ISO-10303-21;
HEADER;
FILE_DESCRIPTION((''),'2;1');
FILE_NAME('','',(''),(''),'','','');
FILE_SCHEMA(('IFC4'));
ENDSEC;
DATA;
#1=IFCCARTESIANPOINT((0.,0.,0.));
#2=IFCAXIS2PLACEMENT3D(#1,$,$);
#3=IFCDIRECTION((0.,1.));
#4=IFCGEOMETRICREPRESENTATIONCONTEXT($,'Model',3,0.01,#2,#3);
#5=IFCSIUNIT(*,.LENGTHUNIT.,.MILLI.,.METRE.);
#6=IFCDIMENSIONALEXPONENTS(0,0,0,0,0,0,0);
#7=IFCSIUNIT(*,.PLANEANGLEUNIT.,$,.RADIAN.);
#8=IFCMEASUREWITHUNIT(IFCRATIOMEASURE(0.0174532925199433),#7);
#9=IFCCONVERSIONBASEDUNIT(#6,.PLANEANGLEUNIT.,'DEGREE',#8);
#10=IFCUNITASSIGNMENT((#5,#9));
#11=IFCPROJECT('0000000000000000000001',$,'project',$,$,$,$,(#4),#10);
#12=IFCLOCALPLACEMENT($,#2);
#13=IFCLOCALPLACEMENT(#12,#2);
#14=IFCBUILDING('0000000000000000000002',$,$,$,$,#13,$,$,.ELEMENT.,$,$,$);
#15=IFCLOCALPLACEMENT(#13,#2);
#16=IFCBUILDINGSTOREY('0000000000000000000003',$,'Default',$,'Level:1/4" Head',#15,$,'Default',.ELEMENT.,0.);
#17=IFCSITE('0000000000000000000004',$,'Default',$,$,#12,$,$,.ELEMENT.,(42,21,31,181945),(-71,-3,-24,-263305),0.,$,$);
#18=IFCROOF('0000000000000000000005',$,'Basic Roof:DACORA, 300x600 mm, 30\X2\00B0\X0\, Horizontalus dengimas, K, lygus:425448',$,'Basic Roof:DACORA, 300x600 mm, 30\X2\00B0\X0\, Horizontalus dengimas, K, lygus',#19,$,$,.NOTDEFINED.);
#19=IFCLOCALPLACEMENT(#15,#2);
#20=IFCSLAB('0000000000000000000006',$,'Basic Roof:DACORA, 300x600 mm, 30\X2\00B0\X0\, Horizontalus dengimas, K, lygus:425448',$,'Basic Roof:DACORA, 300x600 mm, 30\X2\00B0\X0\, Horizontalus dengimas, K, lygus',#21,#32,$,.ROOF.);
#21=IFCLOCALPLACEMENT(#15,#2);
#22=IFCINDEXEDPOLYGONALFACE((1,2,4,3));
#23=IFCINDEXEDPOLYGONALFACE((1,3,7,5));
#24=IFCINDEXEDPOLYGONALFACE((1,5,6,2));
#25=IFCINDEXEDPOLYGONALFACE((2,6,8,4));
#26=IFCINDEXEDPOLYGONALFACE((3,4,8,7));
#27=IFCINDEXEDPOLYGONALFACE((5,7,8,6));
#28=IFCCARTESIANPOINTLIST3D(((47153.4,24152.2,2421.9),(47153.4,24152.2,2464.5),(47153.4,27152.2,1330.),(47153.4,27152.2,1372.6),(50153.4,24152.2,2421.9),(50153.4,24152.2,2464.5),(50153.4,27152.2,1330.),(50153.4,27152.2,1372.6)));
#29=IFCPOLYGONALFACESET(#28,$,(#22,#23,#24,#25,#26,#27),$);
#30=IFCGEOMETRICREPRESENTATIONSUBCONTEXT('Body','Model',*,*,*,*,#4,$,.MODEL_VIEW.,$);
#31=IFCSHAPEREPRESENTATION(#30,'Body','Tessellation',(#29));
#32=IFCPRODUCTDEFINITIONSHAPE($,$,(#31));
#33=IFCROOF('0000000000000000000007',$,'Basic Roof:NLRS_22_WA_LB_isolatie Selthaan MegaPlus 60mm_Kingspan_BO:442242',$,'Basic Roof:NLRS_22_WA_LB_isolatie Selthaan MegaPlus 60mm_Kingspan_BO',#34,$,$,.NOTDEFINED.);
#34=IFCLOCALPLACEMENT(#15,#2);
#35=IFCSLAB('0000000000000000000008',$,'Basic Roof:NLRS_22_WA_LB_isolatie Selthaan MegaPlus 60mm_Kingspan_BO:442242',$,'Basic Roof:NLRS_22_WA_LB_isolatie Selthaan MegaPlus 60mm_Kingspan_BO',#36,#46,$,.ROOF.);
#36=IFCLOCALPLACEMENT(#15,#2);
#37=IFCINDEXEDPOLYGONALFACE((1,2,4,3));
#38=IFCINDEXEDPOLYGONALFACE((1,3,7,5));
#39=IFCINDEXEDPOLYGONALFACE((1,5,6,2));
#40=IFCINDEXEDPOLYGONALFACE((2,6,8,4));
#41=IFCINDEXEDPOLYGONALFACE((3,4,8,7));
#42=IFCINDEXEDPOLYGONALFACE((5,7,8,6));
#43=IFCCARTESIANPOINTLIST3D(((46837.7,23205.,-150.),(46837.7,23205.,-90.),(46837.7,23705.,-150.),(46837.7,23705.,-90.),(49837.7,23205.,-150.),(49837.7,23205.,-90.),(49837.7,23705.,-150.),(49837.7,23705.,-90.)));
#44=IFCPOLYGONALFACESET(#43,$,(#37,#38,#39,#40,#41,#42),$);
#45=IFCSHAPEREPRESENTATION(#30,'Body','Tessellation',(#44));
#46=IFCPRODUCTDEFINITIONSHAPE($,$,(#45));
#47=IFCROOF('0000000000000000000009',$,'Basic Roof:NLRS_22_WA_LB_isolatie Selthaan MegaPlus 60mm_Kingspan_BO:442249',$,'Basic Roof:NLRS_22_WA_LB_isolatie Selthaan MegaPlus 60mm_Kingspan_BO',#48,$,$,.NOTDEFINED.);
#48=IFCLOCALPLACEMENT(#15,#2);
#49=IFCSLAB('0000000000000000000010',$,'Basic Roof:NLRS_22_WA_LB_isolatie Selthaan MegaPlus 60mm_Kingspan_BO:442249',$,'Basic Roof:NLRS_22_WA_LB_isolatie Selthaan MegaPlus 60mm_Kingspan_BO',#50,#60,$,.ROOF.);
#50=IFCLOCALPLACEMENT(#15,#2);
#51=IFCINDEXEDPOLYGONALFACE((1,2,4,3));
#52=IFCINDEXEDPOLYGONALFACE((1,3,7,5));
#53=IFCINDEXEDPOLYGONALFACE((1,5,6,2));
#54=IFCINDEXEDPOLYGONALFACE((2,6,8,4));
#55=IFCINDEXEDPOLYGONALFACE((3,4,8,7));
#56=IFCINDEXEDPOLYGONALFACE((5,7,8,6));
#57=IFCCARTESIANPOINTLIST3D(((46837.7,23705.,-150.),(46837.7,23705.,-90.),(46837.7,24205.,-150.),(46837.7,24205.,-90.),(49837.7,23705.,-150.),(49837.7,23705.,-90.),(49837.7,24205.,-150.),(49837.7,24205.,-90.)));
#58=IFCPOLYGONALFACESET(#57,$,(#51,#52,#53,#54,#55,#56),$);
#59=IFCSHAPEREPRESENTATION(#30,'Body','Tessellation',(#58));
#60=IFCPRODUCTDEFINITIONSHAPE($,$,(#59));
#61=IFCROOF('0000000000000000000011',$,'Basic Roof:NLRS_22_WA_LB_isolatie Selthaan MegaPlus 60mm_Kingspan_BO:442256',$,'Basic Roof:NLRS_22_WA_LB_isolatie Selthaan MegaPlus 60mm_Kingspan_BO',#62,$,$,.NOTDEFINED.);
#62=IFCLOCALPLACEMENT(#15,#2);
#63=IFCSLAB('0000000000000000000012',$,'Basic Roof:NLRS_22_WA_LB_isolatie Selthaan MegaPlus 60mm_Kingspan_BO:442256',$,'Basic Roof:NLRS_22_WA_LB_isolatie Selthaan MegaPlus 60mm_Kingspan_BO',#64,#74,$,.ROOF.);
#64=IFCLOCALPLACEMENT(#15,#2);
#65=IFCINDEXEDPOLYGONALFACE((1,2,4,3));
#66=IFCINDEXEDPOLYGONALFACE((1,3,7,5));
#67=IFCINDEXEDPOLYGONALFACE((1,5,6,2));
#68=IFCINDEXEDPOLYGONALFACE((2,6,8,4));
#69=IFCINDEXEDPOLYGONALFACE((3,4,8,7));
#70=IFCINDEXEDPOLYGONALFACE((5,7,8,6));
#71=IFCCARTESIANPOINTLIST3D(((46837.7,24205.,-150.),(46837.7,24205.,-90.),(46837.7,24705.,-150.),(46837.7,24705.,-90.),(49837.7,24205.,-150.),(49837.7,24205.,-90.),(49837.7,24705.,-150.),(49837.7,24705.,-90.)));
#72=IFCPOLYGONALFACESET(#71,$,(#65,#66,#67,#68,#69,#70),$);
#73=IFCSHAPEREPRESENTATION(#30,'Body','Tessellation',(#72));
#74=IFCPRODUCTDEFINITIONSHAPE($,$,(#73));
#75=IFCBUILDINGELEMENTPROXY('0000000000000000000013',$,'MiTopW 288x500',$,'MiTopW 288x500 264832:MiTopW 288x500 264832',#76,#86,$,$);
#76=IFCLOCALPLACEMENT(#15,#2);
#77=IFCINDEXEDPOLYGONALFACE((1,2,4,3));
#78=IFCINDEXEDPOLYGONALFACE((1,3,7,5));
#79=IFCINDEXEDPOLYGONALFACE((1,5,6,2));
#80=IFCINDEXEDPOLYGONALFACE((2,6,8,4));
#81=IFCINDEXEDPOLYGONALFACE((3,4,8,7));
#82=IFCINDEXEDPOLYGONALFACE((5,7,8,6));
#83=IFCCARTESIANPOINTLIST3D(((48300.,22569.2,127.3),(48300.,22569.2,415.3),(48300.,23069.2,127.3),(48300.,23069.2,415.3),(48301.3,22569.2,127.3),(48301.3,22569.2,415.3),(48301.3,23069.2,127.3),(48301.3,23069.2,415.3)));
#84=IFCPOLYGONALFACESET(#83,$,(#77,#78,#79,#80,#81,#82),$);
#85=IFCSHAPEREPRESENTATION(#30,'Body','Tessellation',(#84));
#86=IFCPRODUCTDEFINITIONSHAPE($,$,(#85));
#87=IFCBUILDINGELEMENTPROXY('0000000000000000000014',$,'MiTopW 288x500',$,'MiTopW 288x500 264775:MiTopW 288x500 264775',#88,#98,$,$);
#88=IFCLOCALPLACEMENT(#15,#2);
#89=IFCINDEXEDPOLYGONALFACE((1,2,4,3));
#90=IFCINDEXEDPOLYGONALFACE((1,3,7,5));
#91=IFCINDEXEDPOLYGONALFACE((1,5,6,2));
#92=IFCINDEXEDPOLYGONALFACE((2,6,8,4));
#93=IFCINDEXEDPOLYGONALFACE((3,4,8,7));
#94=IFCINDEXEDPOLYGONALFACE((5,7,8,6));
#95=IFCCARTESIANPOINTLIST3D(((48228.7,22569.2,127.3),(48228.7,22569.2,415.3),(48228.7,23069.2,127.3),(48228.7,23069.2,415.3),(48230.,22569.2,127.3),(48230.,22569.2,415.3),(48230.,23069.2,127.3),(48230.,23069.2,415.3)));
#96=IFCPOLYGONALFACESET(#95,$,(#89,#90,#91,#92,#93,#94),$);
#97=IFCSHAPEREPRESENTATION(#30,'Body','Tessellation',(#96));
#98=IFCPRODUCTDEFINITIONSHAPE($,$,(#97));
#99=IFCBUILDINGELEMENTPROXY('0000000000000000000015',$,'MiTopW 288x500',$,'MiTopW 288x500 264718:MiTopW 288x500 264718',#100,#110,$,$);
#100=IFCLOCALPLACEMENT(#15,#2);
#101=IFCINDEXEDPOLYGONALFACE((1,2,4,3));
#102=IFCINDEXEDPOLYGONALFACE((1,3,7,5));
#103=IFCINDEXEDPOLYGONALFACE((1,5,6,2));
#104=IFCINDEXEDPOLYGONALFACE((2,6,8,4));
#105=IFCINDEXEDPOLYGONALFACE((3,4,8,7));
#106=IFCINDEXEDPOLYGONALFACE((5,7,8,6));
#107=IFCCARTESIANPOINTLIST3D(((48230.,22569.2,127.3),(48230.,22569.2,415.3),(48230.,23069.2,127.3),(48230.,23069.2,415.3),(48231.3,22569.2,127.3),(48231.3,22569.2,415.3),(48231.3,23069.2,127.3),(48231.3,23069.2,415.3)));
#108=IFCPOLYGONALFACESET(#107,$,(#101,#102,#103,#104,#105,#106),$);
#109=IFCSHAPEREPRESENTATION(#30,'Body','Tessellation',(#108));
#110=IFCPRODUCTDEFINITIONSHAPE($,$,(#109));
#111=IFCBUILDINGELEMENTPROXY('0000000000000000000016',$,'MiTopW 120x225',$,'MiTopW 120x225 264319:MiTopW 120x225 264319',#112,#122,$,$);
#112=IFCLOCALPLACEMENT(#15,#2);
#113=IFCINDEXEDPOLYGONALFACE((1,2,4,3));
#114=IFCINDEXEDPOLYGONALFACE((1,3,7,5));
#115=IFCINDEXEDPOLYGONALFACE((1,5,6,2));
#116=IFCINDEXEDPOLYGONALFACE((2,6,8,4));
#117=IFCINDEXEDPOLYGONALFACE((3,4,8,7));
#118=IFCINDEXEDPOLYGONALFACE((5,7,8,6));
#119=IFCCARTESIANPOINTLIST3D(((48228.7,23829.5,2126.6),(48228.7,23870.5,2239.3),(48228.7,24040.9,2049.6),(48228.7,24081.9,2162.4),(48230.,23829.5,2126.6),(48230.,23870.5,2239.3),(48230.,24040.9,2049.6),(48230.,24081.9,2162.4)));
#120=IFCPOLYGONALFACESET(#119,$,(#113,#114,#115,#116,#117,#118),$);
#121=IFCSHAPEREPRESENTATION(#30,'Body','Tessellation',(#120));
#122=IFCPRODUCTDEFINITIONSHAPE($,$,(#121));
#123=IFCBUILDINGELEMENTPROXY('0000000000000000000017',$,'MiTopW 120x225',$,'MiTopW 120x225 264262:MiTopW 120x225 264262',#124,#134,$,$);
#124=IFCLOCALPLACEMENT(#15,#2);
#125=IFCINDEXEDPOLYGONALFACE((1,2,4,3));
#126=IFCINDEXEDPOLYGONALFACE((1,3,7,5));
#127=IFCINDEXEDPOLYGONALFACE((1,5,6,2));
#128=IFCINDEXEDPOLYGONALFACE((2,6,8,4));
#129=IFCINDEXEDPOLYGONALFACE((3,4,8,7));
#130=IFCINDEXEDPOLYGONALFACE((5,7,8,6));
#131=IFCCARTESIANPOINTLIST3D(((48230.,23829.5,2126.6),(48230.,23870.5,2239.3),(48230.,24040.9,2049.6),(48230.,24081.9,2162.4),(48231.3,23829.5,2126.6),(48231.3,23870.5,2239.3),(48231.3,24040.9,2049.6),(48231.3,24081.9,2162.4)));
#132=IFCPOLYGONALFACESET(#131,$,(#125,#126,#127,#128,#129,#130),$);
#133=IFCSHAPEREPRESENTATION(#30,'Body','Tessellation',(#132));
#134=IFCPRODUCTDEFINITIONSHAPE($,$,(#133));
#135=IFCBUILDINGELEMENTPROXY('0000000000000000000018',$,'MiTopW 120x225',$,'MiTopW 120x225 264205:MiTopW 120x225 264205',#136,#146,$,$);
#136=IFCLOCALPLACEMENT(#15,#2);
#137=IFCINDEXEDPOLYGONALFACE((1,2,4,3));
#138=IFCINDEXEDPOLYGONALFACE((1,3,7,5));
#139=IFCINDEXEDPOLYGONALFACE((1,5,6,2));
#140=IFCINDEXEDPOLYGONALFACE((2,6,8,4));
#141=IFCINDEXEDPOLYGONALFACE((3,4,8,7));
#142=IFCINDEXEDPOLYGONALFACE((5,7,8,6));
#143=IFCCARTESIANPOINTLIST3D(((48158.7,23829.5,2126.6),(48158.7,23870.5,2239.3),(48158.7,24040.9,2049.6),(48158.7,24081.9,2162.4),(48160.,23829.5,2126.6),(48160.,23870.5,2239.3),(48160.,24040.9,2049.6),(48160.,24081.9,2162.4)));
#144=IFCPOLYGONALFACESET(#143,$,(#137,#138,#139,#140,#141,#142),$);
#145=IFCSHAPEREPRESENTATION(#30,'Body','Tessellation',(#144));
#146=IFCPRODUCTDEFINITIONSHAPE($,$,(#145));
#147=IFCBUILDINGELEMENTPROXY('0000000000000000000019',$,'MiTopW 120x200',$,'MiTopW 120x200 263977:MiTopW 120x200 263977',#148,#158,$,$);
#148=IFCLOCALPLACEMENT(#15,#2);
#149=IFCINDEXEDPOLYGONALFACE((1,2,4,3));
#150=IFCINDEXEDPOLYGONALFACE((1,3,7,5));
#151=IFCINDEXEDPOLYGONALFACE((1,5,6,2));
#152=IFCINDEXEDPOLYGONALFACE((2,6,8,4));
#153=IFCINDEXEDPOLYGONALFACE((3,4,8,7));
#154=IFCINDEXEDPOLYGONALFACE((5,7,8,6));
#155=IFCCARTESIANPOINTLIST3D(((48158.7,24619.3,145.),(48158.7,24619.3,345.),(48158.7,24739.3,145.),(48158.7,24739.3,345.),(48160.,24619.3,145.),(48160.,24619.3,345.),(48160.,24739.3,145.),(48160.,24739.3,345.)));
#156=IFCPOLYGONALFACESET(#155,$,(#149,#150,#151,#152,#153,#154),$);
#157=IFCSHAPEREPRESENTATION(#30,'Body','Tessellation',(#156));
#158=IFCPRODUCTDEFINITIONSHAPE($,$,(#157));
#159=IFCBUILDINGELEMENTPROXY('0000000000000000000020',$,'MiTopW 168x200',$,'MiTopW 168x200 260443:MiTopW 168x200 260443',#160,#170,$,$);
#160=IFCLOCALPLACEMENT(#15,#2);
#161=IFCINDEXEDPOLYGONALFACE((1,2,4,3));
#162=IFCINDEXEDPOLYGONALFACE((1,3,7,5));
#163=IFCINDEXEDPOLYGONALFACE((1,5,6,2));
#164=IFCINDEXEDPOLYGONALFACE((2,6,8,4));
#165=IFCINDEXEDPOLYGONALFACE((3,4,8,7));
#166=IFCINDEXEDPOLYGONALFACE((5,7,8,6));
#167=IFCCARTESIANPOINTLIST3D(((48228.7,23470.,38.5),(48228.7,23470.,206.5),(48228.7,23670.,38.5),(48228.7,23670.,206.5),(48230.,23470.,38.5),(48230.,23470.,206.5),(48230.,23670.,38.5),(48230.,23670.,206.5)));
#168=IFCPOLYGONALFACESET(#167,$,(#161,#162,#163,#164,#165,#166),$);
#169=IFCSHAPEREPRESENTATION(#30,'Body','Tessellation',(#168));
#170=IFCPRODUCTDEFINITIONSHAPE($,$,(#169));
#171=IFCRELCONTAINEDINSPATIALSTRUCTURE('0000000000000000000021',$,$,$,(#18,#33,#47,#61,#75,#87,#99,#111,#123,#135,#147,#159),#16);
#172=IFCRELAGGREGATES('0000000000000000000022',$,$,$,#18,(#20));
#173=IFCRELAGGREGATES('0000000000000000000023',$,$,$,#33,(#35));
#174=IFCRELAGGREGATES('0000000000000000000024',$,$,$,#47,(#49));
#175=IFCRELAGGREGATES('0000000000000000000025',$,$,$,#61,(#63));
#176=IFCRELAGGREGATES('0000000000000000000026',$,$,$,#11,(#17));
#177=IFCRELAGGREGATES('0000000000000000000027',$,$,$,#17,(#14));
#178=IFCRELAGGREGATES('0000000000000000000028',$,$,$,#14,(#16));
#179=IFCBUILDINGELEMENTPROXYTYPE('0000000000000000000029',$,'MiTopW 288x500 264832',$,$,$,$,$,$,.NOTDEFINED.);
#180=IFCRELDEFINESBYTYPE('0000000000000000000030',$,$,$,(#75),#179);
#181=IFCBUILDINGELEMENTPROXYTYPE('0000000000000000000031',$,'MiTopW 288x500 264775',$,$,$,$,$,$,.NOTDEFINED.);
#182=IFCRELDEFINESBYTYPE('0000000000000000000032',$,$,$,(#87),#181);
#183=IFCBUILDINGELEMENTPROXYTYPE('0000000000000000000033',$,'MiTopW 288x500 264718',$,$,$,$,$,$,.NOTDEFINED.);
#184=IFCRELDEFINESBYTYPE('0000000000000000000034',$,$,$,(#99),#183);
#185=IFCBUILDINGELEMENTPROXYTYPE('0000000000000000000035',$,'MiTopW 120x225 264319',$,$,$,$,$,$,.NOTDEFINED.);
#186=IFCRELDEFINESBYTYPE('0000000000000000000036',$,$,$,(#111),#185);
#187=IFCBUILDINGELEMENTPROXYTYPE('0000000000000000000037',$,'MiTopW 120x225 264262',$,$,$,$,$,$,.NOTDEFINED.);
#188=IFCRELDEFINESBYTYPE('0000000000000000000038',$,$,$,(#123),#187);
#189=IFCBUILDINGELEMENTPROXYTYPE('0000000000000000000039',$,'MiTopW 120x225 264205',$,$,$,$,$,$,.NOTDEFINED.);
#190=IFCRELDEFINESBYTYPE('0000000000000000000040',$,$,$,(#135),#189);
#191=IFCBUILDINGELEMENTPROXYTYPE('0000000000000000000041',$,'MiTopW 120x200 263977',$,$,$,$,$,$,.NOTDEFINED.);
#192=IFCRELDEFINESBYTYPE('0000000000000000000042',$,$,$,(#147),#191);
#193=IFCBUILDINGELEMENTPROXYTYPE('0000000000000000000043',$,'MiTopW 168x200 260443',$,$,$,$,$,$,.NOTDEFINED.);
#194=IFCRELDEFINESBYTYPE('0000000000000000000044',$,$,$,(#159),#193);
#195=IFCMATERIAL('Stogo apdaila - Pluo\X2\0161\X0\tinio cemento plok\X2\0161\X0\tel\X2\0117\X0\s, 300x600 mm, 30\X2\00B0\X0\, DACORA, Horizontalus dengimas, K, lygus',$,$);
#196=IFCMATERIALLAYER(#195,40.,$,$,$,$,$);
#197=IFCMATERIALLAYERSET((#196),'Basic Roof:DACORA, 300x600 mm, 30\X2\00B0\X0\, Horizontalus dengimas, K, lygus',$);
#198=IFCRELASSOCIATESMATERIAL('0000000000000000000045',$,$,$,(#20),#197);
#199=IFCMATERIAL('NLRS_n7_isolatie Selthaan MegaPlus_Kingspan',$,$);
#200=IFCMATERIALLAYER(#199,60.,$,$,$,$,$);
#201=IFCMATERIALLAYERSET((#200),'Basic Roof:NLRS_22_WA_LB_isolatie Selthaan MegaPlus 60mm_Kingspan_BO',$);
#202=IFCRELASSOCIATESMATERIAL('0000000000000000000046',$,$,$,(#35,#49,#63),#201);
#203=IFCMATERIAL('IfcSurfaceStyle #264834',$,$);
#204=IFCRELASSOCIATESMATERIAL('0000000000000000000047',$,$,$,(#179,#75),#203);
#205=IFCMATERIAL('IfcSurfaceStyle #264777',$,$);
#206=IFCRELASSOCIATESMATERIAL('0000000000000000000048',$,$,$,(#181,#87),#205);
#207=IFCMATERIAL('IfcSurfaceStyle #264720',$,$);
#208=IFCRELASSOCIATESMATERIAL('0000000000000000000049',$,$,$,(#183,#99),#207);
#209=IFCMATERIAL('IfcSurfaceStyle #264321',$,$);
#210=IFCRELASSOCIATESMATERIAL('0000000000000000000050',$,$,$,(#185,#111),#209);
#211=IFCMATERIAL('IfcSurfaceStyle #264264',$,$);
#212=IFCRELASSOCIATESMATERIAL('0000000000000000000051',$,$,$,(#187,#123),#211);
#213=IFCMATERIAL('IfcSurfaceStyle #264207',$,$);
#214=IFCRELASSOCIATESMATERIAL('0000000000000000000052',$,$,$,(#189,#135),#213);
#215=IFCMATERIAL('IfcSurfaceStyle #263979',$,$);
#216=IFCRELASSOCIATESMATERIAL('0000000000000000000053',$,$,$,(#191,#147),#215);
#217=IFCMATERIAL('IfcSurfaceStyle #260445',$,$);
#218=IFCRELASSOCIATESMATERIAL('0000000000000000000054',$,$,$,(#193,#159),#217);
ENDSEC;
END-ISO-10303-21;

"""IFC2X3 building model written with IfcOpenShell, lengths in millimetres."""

from ifc_helpers import new_model, entity, si_unit, converted_unit, direction, frame, frame_2d, origin, origin_2d_with_axis, place, context, subcontext, project, spatial, polyline, rectangle, outline, extrude, source, transform, mapped, material, layer, layer_set, type_object, type_shapes, element, aggregate, save


model = new_model("IFC2X3")

# Units and contexts
model_context = context("Model", 3, precision=0.01, world=origin(), true_north=direction((0.0, 1.0)))
body_context = subcontext(model_context, "Body", "Model", "MODEL_VIEW")
ifc_project = project(units=[si_unit("LENGTHUNIT", "METRE", prefix="MILLI"), converted_unit("PLANEANGLEUNIT", "DEGREE", entity("IfcRatioMeasure", 0.0174532925199433), si_unit("PLANEANGLEUNIT", "RADIAN"), dimensions=[0, 0, 0, 0, 0, 0, 0])], contexts=[model_context])

# Site, building, storey
site_placement = place(None, origin())
site = spatial("IfcSite", under=ifc_project, at=site_placement, Name="Default", CompositionType="ELEMENT", RefLatitude=(42, 21, 31, 181945), RefLongitude=(-71, -3, -24, -263305), RefElevation=0.0)
building_placement = place(site_placement, origin())
building = spatial("IfcBuilding", under=site, at=building_placement, CompositionType="ELEMENT")
storey_placement = place(building_placement, origin())
storey = spatial("IfcBuildingStorey", under=building, at=storey_placement, Name="Default", ObjectType="Level:1/4\" Head", LongName="Default", CompositionType="ELEMENT", Elevation=0.0)

# Roofs, slabs
roof_1_placement = place(storey_placement, frame((47153.4, 24152.2, 1330.0)))
roof_1 = element("IfcRoof", 1, at=roof_1_placement, inside=storey, Name="Basic Roof:DACORA, 300x600 mm, 30°, Horizontalus dengimas, K, lygus:425448", ObjectType="Basic Roof:DACORA, 300x600 mm, 30°, Horizontalus dengimas, K, lygus", ShapeType="NOTDEFINED")
ifc_material_1 = material(Name="Stogo apdaila - Pluoštinio cemento plokštelės, 300x600 mm, 30°, DACORA, Horizontalus dengimas, K, lygus")
ifc_layer_1 = layer(ifc_material_1, 40.0)
ifc_layer_set_1 = layer_set([ifc_layer_1], Name="Basic Roof:DACORA, 300x600 mm, 30°, Horizontalus dengimas, K, lygus")
slab_1_placement = place(roof_1_placement, origin())
slab_1 = element("IfcSlab", 2, at=slab_1_placement, material=ifc_layer_set_1, Name="Basic Roof:DACORA, 300x600 mm, 30°, Horizontalus dengimas, K, lygus:425448", ObjectType="Basic Roof:DACORA, 300x600 mm, 30°, Horizontalus dengimas, K, lygus", PredefinedType="ROOF", context=body_context, shape_type="SweptSolid", body=[
    extrude(rectangle(XDim=3192.5, YDim=3000.0, at=frame_2d((0.0, 0.0), x_axis=(0.0, 1.0))), frame((1500.0, 1500.0, 546.0), z_axis=(0.0, 0.34202, 0.939693), x_axis=(1.0, 0.0, 0.0)), (0.0, -0.34202, 0.939693), 42.6),
])
aggregate(roof_1, [slab_1])
roof_2_placement = place(storey_placement, frame((46837.7, 23205.0, -150.0)))
roof_2 = element("IfcRoof", 3, at=roof_2_placement, inside=storey, Name="Basic Roof:NLRS_22_WA_LB_isolatie Selthaan MegaPlus 60mm_Kingspan_BO:442242", ObjectType="Basic Roof:NLRS_22_WA_LB_isolatie Selthaan MegaPlus 60mm_Kingspan_BO", ShapeType="NOTDEFINED")
ifc_material_2 = material(Name="NLRS_n7_isolatie Selthaan MegaPlus_Kingspan")
ifc_layer_2 = layer(ifc_material_2, 60.0)
ifc_layer_set_2 = layer_set([ifc_layer_2], Name="Basic Roof:NLRS_22_WA_LB_isolatie Selthaan MegaPlus 60mm_Kingspan_BO")
slab_2_placement = place(roof_2_placement, origin())
slab_2 = element("IfcSlab", 4, at=slab_2_placement, material=ifc_layer_set_2, Name="Basic Roof:NLRS_22_WA_LB_isolatie Selthaan MegaPlus 60mm_Kingspan_BO:442242", ObjectType="Basic Roof:NLRS_22_WA_LB_isolatie Selthaan MegaPlus 60mm_Kingspan_BO", PredefinedType="ROOF", context=body_context, shape_type="SweptSolid", body=[
    extrude(rectangle(XDim=3000.0, YDim=500.0, at=origin_2d_with_axis()), frame((1500.0, 250.0, 0.0)), (0.0, 0.0, 1.0), 60.0),
])
aggregate(roof_2, [slab_2])
roof_3_placement = place(storey_placement, frame((46837.7, 23705.0, -150.0)))
roof_3 = element("IfcRoof", 5, at=roof_3_placement, inside=storey, Name="Basic Roof:NLRS_22_WA_LB_isolatie Selthaan MegaPlus 60mm_Kingspan_BO:442249", ObjectType="Basic Roof:NLRS_22_WA_LB_isolatie Selthaan MegaPlus 60mm_Kingspan_BO", ShapeType="NOTDEFINED")
slab_3_placement = place(roof_3_placement, origin())
slab_3 = element("IfcSlab", 6, at=slab_3_placement, material=ifc_layer_set_2, Name="Basic Roof:NLRS_22_WA_LB_isolatie Selthaan MegaPlus 60mm_Kingspan_BO:442249", ObjectType="Basic Roof:NLRS_22_WA_LB_isolatie Selthaan MegaPlus 60mm_Kingspan_BO", PredefinedType="ROOF", context=body_context, shape_type="SweptSolid", body=[
    extrude(rectangle(XDim=3000.0, YDim=500.0, at=origin_2d_with_axis()), frame((1500.0, 250.0, 0.0)), (0.0, 0.0, 1.0), 60.0),
])
aggregate(roof_3, [slab_3])
roof_4_placement = place(storey_placement, frame((46837.7, 24205.0, -150.0)))
roof_4 = element("IfcRoof", 7, at=roof_4_placement, inside=storey, Name="Basic Roof:NLRS_22_WA_LB_isolatie Selthaan MegaPlus 60mm_Kingspan_BO:442256", ObjectType="Basic Roof:NLRS_22_WA_LB_isolatie Selthaan MegaPlus 60mm_Kingspan_BO", ShapeType="NOTDEFINED")
slab_4_placement = place(roof_4_placement, origin())
slab_4 = element("IfcSlab", 8, at=slab_4_placement, material=ifc_layer_set_2, Name="Basic Roof:NLRS_22_WA_LB_isolatie Selthaan MegaPlus 60mm_Kingspan_BO:442256", ObjectType="Basic Roof:NLRS_22_WA_LB_isolatie Selthaan MegaPlus 60mm_Kingspan_BO", PredefinedType="ROOF", context=body_context, shape_type="SweptSolid", body=[
    extrude(rectangle(XDim=3000.0, YDim=500.0, at=origin_2d_with_axis()), frame((1500.0, 250.0, 0.0)), (0.0, 0.0, 1.0), 60.0),
])
aggregate(roof_4, [slab_4])

# Building element proxies
ifc_material_3 = material(Name="IfcSurfaceStyle #264834")
building_element_proxy_type_1 = type_object("IfcBuildingElementProxyType", Name="MiTopW 288x500 264832", PredefinedType="NOTDEFINED", material=ifc_material_3)
shared_shape_1 = source(origin(), body_context, "Body", "SweptSolid", [
    extrude(rectangle(XDim=500.0, YDim=288.0, at=origin_2d_with_axis()), frame((250.0, 144.0, 0.0), z_axis=(0.0, 0.0, 1.0), x_axis=(-1.0, 0.0, 0.0)), (0.0, 0.0, 1.0), 1.3),
])
type_shapes(building_element_proxy_type_1, [shared_shape_1])
proxy_1_placement = place(building_placement, frame((48301.3, 23069.2, 127.3), z_axis=(-1.0, 0.0, 0.0), x_axis=(0.0, -1.0, 0.0)))
element("IfcBuildingElementProxy", 9, at=proxy_1_placement, inside=storey, type_object=building_element_proxy_type_1, material=ifc_material_3, Name="MiTopW 288x500", ObjectType="MiTopW 288x500 264832:MiTopW 288x500 264832", context=body_context, shape_type="MappedRepresentation", body=[
    mapped(shared_shape_1, transform((0.0, 0.0, 0.0), scale=1.0)),
])
ifc_material_4 = material(Name="IfcSurfaceStyle #264777")
building_element_proxy_type_2 = type_object("IfcBuildingElementProxyType", Name="MiTopW 288x500 264775", PredefinedType="NOTDEFINED", material=ifc_material_4)
shared_shape_2 = source(origin(), body_context, "Body", "SweptSolid", [
    extrude(rectangle(XDim=500.0, YDim=288.0, at=origin_2d_with_axis()), frame((250.0, 144.0, 0.0), z_axis=(0.0, 0.0, 1.0), x_axis=(-1.0, 0.0, 0.0)), (0.0, 0.0, 1.0), 1.3),
])
type_shapes(building_element_proxy_type_2, [shared_shape_2])
proxy_2_placement = place(building_placement, frame((48230.0, 23069.2, 127.3), z_axis=(-1.0, 0.0, 0.0), x_axis=(0.0, -1.0, 0.0)))
element("IfcBuildingElementProxy", 10, at=proxy_2_placement, inside=storey, type_object=building_element_proxy_type_2, material=ifc_material_4, Name="MiTopW 288x500", ObjectType="MiTopW 288x500 264775:MiTopW 288x500 264775", context=body_context, shape_type="MappedRepresentation", body=[
    mapped(shared_shape_2, transform((0.0, 0.0, 0.0), scale=1.0)),
])
ifc_material_5 = material(Name="IfcSurfaceStyle #264720")
building_element_proxy_type_3 = type_object("IfcBuildingElementProxyType", Name="MiTopW 288x500 264718", PredefinedType="NOTDEFINED", material=ifc_material_5)
shared_shape_3 = source(origin(), body_context, "Body", "SweptSolid", [
    extrude(rectangle(XDim=500.0, YDim=288.0, at=origin_2d_with_axis()), frame((250.0, 144.0, 0.0), z_axis=(0.0, 0.0, 1.0), x_axis=(-1.0, 0.0, 0.0)), (0.0, 0.0, 1.0), 1.3),
])
type_shapes(building_element_proxy_type_3, [shared_shape_3])
proxy_3_placement = place(building_placement, frame((48231.3, 23069.2, 127.3), z_axis=(-1.0, 0.0, 0.0), x_axis=(0.0, -1.0, 0.0)))
element("IfcBuildingElementProxy", 11, at=proxy_3_placement, inside=storey, type_object=building_element_proxy_type_3, material=ifc_material_5, Name="MiTopW 288x500", ObjectType="MiTopW 288x500 264718:MiTopW 288x500 264718", context=body_context, shape_type="MappedRepresentation", body=[
    mapped(shared_shape_3, transform((0.0, 0.0, 0.0), scale=1.0)),
])
ifc_material_6 = material(Name="IfcSurfaceStyle #264321")
building_element_proxy_type_4 = type_object("IfcBuildingElementProxyType", Name="MiTopW 120x225 264319", PredefinedType="NOTDEFINED", material=ifc_material_6)
shared_shape_4 = source(origin(), body_context, "Body", "SweptSolid", [
    extrude(outline(polyline([(-112.5, -60.0), (112.5, -60.0), (112.5, 60.0), (-112.5, 60.0), (-112.5, -60.0)])), frame((112.5, 60.0, 0.0), z_axis=(0.0, 0.0, 1.0), x_axis=(-1.0, 0.0, 0.0)), (0.0, 0.0, 1.0), 1.3),
])
type_shapes(building_element_proxy_type_4, [shared_shape_4])
proxy_4_placement = place(building_placement, frame((48230.0, 24040.9, 2049.6), z_axis=(-1.0, 0.0, 0.0), x_axis=(0.0, -0.939693, 0.34202)))
element("IfcBuildingElementProxy", 12, at=proxy_4_placement, inside=storey, type_object=building_element_proxy_type_4, material=ifc_material_6, Name="MiTopW 120x225", ObjectType="MiTopW 120x225 264319:MiTopW 120x225 264319", context=body_context, shape_type="MappedRepresentation", body=[
    mapped(shared_shape_4, transform((0.0, 0.0, 0.0), scale=1.0)),
])
ifc_material_7 = material(Name="IfcSurfaceStyle #264264")
building_element_proxy_type_5 = type_object("IfcBuildingElementProxyType", Name="MiTopW 120x225 264262", PredefinedType="NOTDEFINED", material=ifc_material_7)
shared_shape_5 = source(origin(), body_context, "Body", "SweptSolid", [
    extrude(outline(polyline([(-112.5, -60.0), (112.5, -60.0), (112.5, 60.0), (-112.5, 60.0), (-112.5, -60.0)])), frame((112.5, 60.0, 0.0), z_axis=(0.0, 0.0, 1.0), x_axis=(-1.0, 0.0, 0.0)), (0.0, 0.0, 1.0), 1.3),
])
type_shapes(building_element_proxy_type_5, [shared_shape_5])
proxy_5_placement = place(building_placement, frame((48231.3, 24040.9, 2049.6), z_axis=(-1.0, 0.0, 0.0), x_axis=(0.0, -0.939693, 0.34202)))
element("IfcBuildingElementProxy", 13, at=proxy_5_placement, inside=storey, type_object=building_element_proxy_type_5, material=ifc_material_7, Name="MiTopW 120x225", ObjectType="MiTopW 120x225 264262:MiTopW 120x225 264262", context=body_context, shape_type="MappedRepresentation", body=[
    mapped(shared_shape_5, transform((0.0, 0.0, 0.0), scale=1.0)),
])
ifc_material_8 = material(Name="IfcSurfaceStyle #264207")
building_element_proxy_type_6 = type_object("IfcBuildingElementProxyType", Name="MiTopW 120x225 264205", PredefinedType="NOTDEFINED", material=ifc_material_8)
shared_shape_6 = source(origin(), body_context, "Body", "SweptSolid", [
    extrude(outline(polyline([(-112.5, -60.0), (112.5, -60.0), (112.5, 60.0), (-112.5, 60.0), (-112.5, -60.0)])), frame((112.5, 60.0, 0.0), z_axis=(0.0, 0.0, 1.0), x_axis=(-1.0, 0.0, 0.0)), (0.0, 0.0, 1.0), 1.3),
])
type_shapes(building_element_proxy_type_6, [shared_shape_6])
proxy_6_placement = place(building_placement, frame((48160.0, 24040.9, 2049.6), z_axis=(-1.0, 0.0, 0.0), x_axis=(0.0, -0.939693, 0.34202)))
element("IfcBuildingElementProxy", 14, at=proxy_6_placement, inside=storey, type_object=building_element_proxy_type_6, material=ifc_material_8, Name="MiTopW 120x225", ObjectType="MiTopW 120x225 264205:MiTopW 120x225 264205", context=body_context, shape_type="MappedRepresentation", body=[
    mapped(shared_shape_6, transform((0.0, 0.0, 0.0), scale=1.0)),
])
ifc_material_9 = material(Name="IfcSurfaceStyle #263979")
building_element_proxy_type_7 = type_object("IfcBuildingElementProxyType", Name="MiTopW 120x200 263977", PredefinedType="NOTDEFINED", material=ifc_material_9)
shared_shape_7 = source(origin(), body_context, "Body", "SweptSolid", [
    extrude(rectangle(XDim=200.0, YDim=120.0, at=origin_2d_with_axis()), frame((100.0, 60.0, 0.0), z_axis=(0.0, 0.0, 1.0), x_axis=(-1.0, 0.0, 0.0)), (0.0, 0.0, 1.0), 1.3),
])
type_shapes(building_element_proxy_type_7, [shared_shape_7])
proxy_7_placement = place(building_placement, frame((48160.0, 24619.3, 145.0), z_axis=(-1.0, 0.0, 0.0), x_axis=(0.0, 0.0, 1.0)))
element("IfcBuildingElementProxy", 15, at=proxy_7_placement, inside=storey, type_object=building_element_proxy_type_7, material=ifc_material_9, Name="MiTopW 120x200", ObjectType="MiTopW 120x200 263977:MiTopW 120x200 263977", context=body_context, shape_type="MappedRepresentation", body=[
    mapped(shared_shape_7, transform((0.0, 0.0, 0.0), scale=1.0)),
])
ifc_material_10 = material(Name="IfcSurfaceStyle #260445")
building_element_proxy_type_8 = type_object("IfcBuildingElementProxyType", Name="MiTopW 168x200 260443", PredefinedType="NOTDEFINED", material=ifc_material_10)
shared_shape_8 = source(origin(), body_context, "Body", "SweptSolid", [
    extrude(rectangle(XDim=200.0, YDim=168.0, at=origin_2d_with_axis()), frame((100.0, 84.0, 0.0), z_axis=(0.0, 0.0, 1.0), x_axis=(-1.0, 0.0, 0.0)), (0.0, 0.0, 1.0), 1.3),
])
type_shapes(building_element_proxy_type_8, [shared_shape_8])
proxy_8_placement = place(building_placement, frame((48230.0, 23470.0, 206.5), z_axis=(-1.0, 0.0, 0.0), x_axis=(0.0, 1.0, 0.0)))
element("IfcBuildingElementProxy", 16, at=proxy_8_placement, inside=storey, type_object=building_element_proxy_type_8, material=ifc_material_10, Name="MiTopW 168x200", ObjectType="MiTopW 168x200 260443:MiTopW 168x200 260443", context=body_context, shape_type="MappedRepresentation", body=[
    mapped(shared_shape_8, transform((0.0, 0.0, 0.0), scale=1.0)),
])

save(model, "model.ifc")
